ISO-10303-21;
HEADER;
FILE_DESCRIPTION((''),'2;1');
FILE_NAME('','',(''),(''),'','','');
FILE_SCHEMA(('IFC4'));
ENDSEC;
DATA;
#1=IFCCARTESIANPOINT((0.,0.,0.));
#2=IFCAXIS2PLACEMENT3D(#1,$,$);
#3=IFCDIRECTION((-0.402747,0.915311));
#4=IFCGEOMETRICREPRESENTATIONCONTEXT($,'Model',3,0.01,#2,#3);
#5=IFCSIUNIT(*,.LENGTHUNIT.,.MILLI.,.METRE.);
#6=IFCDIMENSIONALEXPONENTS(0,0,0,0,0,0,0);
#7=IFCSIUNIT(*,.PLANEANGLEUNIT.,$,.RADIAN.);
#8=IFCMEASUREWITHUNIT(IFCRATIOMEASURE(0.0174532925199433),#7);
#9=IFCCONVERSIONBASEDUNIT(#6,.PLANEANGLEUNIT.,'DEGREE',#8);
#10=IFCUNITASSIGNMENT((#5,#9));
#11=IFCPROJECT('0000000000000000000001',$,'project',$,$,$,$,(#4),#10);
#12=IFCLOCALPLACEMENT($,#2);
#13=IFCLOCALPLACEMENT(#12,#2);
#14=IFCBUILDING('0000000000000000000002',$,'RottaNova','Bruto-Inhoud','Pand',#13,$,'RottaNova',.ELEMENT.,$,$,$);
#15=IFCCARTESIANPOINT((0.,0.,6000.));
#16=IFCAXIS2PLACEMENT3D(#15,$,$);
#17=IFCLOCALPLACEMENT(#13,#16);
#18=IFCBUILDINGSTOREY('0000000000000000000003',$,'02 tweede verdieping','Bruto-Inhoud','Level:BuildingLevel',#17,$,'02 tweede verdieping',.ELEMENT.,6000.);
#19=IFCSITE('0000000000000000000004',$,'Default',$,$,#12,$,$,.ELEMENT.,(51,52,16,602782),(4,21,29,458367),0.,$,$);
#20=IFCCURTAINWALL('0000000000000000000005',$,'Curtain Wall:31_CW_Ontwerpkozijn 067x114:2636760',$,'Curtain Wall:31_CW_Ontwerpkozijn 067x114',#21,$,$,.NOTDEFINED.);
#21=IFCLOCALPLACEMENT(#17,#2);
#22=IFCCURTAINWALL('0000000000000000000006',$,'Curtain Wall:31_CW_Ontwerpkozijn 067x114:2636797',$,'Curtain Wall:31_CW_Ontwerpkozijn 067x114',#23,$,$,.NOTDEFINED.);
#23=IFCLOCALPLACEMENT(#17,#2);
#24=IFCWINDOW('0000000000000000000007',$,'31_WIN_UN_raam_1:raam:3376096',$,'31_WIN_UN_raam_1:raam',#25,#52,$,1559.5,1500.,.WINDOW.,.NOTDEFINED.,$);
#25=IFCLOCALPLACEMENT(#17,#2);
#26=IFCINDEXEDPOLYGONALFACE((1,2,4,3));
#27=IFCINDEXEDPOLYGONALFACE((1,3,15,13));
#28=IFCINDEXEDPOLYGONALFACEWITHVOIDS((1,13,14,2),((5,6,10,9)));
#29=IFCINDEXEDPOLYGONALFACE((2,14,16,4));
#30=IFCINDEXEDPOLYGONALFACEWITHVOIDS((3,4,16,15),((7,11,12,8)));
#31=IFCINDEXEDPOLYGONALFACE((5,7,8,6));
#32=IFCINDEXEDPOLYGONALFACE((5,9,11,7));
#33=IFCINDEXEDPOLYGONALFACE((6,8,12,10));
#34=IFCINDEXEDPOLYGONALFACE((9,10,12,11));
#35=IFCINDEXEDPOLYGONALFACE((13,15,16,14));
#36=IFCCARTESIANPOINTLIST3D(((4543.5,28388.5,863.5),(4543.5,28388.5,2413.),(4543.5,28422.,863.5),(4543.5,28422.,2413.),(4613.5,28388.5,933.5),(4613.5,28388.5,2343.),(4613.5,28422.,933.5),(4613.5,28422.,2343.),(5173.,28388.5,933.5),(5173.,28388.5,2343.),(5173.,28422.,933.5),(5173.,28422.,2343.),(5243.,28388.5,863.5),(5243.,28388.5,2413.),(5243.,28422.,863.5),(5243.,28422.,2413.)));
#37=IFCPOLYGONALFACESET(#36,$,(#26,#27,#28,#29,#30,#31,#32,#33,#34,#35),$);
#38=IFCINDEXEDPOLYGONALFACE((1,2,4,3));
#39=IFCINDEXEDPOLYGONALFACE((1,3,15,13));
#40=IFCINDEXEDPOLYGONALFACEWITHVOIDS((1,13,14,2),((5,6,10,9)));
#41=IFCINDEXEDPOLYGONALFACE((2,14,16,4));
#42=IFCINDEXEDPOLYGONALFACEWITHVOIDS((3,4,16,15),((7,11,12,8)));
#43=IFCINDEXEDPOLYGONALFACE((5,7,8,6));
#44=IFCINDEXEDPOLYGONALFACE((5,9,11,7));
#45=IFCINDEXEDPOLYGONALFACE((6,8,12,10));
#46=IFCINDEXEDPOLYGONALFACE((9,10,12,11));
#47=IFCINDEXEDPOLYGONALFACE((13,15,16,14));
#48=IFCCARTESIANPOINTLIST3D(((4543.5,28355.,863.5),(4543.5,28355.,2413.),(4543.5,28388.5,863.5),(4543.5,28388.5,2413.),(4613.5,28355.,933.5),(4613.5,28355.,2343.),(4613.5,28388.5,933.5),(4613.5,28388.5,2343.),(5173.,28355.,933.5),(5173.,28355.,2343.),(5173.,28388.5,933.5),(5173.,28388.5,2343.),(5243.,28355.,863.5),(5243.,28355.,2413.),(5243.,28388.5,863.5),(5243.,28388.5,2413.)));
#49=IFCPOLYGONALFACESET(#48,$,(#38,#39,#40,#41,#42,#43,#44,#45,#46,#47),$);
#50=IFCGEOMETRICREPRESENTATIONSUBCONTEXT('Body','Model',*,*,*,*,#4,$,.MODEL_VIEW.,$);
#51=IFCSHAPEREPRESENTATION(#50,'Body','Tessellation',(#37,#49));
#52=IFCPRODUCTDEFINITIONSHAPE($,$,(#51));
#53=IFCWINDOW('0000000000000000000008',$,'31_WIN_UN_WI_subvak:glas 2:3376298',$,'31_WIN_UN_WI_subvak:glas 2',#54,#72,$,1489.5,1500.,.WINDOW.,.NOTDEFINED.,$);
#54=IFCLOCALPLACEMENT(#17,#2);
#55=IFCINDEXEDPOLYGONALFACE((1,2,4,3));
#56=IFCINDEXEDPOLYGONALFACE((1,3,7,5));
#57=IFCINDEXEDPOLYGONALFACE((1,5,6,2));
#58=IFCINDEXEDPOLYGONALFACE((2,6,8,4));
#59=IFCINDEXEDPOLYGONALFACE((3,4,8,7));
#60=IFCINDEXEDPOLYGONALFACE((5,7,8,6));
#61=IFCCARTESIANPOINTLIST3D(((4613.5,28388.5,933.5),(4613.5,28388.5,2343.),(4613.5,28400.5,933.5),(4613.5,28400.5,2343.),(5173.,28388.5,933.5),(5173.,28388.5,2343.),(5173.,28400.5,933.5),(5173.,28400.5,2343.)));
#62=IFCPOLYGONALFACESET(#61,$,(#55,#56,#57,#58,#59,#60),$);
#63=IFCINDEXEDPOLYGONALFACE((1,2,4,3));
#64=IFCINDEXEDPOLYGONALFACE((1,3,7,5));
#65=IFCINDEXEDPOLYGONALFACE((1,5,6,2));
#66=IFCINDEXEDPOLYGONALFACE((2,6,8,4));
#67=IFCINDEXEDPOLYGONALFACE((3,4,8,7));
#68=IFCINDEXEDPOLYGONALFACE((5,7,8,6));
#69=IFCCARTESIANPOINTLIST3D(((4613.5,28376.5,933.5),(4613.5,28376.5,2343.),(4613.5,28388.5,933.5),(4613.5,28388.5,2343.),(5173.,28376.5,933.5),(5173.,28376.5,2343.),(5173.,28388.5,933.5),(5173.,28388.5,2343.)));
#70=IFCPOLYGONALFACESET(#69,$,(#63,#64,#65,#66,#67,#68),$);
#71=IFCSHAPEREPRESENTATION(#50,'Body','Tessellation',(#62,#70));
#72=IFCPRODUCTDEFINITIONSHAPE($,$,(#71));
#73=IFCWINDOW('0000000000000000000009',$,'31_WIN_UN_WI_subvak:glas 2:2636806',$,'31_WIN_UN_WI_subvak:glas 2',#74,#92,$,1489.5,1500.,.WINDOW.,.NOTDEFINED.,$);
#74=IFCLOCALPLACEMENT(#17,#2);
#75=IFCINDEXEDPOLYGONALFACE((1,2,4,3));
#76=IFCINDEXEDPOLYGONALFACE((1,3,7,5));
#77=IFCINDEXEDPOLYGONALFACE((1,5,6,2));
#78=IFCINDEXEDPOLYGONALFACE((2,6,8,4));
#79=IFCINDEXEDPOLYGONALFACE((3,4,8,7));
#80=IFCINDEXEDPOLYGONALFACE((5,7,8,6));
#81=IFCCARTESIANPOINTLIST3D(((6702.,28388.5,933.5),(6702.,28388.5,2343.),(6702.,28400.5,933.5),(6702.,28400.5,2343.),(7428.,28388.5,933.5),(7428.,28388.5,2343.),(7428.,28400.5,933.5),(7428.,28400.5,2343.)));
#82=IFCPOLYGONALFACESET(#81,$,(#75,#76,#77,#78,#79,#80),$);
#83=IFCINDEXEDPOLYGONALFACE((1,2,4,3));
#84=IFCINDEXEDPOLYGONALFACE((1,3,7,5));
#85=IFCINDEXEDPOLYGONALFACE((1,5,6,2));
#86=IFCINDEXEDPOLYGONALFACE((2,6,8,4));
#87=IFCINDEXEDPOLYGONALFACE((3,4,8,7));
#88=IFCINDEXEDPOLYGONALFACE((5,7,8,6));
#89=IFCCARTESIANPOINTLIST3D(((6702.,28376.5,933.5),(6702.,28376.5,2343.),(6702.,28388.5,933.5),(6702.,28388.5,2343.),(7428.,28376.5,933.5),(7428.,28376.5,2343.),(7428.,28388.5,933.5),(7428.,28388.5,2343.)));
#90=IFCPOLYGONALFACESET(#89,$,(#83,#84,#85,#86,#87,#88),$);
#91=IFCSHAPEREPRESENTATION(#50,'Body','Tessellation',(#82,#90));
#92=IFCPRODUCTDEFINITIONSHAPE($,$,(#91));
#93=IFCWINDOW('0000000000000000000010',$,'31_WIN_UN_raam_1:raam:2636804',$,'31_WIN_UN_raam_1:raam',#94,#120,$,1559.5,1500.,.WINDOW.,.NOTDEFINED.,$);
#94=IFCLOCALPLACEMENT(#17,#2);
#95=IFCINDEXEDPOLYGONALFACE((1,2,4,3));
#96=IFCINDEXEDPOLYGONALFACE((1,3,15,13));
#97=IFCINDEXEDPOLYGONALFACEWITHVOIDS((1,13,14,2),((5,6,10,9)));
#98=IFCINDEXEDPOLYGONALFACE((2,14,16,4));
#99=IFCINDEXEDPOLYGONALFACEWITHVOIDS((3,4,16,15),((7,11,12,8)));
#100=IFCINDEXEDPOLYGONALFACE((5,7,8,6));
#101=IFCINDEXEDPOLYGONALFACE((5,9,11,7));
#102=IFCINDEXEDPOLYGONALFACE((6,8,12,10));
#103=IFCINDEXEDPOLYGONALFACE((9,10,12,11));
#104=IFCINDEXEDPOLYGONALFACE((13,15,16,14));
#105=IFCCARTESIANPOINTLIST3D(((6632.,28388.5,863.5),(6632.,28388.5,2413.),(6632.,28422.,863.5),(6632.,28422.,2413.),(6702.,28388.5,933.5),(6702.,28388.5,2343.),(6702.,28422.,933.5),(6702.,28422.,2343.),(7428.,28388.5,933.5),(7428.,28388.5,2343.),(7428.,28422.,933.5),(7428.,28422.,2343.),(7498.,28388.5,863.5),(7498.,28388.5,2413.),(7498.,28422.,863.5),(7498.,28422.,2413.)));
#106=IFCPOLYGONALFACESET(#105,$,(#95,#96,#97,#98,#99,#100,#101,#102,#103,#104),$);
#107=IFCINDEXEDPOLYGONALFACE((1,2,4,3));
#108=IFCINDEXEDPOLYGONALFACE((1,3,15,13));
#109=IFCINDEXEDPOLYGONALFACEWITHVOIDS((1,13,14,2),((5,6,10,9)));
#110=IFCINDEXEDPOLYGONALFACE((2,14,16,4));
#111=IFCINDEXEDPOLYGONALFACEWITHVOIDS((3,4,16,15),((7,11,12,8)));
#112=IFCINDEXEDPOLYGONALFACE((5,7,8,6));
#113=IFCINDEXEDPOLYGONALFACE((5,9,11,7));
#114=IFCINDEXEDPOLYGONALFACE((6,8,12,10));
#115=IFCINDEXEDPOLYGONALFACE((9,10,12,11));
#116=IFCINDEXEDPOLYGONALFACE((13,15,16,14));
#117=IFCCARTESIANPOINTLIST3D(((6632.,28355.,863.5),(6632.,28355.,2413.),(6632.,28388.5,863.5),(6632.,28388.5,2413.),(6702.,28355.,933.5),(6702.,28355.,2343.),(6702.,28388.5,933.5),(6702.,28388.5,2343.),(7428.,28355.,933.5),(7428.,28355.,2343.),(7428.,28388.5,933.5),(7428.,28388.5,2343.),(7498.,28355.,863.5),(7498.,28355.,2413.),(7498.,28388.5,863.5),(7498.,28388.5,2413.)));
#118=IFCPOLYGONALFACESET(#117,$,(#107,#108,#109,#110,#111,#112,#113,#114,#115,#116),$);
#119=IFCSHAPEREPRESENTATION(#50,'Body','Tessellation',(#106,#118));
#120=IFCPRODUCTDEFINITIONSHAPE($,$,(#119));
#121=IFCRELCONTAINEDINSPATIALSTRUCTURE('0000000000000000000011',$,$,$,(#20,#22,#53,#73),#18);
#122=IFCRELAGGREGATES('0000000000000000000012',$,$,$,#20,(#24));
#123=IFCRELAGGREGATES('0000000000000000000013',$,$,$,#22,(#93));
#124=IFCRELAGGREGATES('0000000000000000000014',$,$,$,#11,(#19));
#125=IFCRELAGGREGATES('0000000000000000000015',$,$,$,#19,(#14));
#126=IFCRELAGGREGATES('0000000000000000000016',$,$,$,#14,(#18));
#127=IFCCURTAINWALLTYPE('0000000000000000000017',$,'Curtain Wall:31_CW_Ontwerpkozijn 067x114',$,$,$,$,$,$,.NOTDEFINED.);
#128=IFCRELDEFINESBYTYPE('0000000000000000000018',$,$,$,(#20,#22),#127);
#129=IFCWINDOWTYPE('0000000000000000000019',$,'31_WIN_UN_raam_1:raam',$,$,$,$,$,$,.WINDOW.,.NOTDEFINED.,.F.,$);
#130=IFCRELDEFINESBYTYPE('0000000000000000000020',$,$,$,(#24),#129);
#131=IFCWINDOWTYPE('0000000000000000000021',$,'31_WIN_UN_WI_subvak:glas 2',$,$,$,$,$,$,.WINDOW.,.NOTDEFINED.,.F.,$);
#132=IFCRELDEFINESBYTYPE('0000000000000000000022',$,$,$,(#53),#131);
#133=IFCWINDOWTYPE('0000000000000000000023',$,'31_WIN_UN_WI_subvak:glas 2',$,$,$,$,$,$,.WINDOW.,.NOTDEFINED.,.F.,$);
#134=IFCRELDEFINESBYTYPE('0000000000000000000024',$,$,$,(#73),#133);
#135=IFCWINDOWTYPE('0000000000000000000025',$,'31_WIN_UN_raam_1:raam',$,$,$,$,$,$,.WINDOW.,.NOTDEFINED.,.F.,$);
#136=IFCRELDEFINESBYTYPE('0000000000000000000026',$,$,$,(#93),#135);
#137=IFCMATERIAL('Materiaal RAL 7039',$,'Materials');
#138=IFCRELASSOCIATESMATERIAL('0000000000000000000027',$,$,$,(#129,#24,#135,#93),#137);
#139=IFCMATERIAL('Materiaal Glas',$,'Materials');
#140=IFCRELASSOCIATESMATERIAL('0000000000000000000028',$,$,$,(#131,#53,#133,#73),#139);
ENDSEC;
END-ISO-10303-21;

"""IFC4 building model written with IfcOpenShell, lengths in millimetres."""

from ifc_helpers import new_model, entity, si_unit, converted_unit, direction, frame, frame_2d, origin, origin_2d_with_axis, place, context, subcontext, project, spatial, polyline, rectangle, outline, extrude, source, transform, mapped, material, type_object, type_shapes, element, aggregate, save


model = new_model("IFC4")

# Units and contexts
model_context = context("Model", 3, precision=0.01, world=origin(), true_north=direction((-0.402747, 0.915311)))
body_context = subcontext(model_context, "Body", "Model", "MODEL_VIEW")
ifc_project = project(units=[si_unit("LENGTHUNIT", "METRE", prefix="MILLI"), converted_unit("PLANEANGLEUNIT", "DEGREE", entity("IfcRatioMeasure", 0.0174532925199433), si_unit("PLANEANGLEUNIT", "RADIAN"), dimensions=[0, 0, 0, 0, 0, 0, 0])], contexts=[model_context])

# Site, building, storey
site_placement = place(None, origin())
site = spatial("IfcSite", under=ifc_project, at=site_placement, Name="Default", CompositionType="ELEMENT", RefLatitude=(51, 52, 16, 602782), RefLongitude=(4, 21, 29, 458367), RefElevation=0.0)
building_placement = place(site_placement, origin())
building = spatial("IfcBuilding", under=site, at=building_placement, Name="RottaNova", Description="Bruto-Inhoud", ObjectType="Pand", LongName="RottaNova", CompositionType="ELEMENT")
storey_placement = place(building_placement, frame((0.0, 0.0, 6000.0)))
storey = spatial("IfcBuildingStorey", under=building, at=storey_placement, Name="02 tweede verdieping", Description="Bruto-Inhoud", ObjectType="Level:BuildingLevel", LongName="02 tweede verdieping", CompositionType="ELEMENT", Elevation=6000.0)

# Shared definitions
curtain_wall_type = type_object("IfcCurtainWallType", Name="Curtain Wall:31_CW_Ontwerpkozijn 067x114", PredefinedType="NOTDEFINED")

# Curtain walls
curtain_wall_1_placement = place(storey_placement, frame((0.0, 0.0, -6000.0)))
curtain_wall_1 = element("IfcCurtainWall", 1, at=curtain_wall_1_placement, inside=storey, type_object=curtain_wall_type, Name="Curtain Wall:31_CW_Ontwerpkozijn 067x114:2636760", ObjectType="Curtain Wall:31_CW_Ontwerpkozijn 067x114", PredefinedType="NOTDEFINED")
curtain_wall_2_placement = place(storey_placement, frame((0.0, 0.0, -6000.0)))
curtain_wall_2 = element("IfcCurtainWall", 2, at=curtain_wall_2_placement, inside=storey, type_object=curtain_wall_type, Name="Curtain Wall:31_CW_Ontwerpkozijn 067x114:2636797", ObjectType="Curtain Wall:31_CW_Ontwerpkozijn 067x114", PredefinedType="NOTDEFINED")

# Shared definitions
ifc_material_1 = material(Name="Materiaal Glas", Category="Materials")

# Window
ifc_material_2 = material(Name="Materiaal RAL 7039", Category="Materials")
window_type_1 = type_object("IfcWindowType", Name="31_WIN_UN_raam_1:raam", ParameterTakesPrecedence=False, PartitioningType="NOTDEFINED", PredefinedType="WINDOW", material=ifc_material_2)
shared_shape_1 = source(origin(), body_context, "Body", "SweptSolid", [
    extrude(outline(polyline([(-349.7, -774.7), (349.7, -774.7), (349.7, 774.7), (-349.7, 774.7), (-349.7, -774.7)]), holes=[polyline([(-279.7, 704.7), (279.7, 704.7), (279.7, -704.8), (-279.7, -704.8), (-279.7, 704.7)])]), frame((0.0, 92.0, 774.8), z_axis=(0.0, -1.0, 0.0), x_axis=(-1.0, 0.0, 0.0)), (0.0, 0.0, 1.0), 33.5),
    extrude(outline(polyline([(-349.7, -774.7), (349.7, -774.7), (349.7, 774.7), (-349.7, 774.7), (-349.7, -774.7)]), holes=[polyline([(-279.7, 704.7), (279.7, 704.7), (279.7, -704.8), (-279.7, -704.8), (-279.7, 704.7)])]), frame((0.0, 58.5, 774.8), z_axis=(0.0, -1.0, 0.0), x_axis=(-1.0, 0.0, 0.0)), (0.0, 0.0, 1.0), 33.5),
])
type_shapes(window_type_1, [shared_shape_1])
window_1_placement = place(curtain_wall_1_placement, frame((4893.2, 28330.0, 6863.5)))
window_1 = element("IfcWindow", 3, at=window_1_placement, type_object=window_type_1, material=ifc_material_2, Name="31_WIN_UN_raam_1:raam:3376096", ObjectType="31_WIN_UN_raam_1:raam", OverallHeight=1559.5, OverallWidth=1500.0, PartitioningType="NOTDEFINED", PredefinedType="WINDOW", context=body_context, shape_type="MappedRepresentation", body=[
    mapped(shared_shape_1, transform((0.0, 0.0, 0.0), scale=1.0)),
])
aggregate(curtain_wall_1, [window_1])

# Windows
window_type_2 = type_object("IfcWindowType", Name="31_WIN_UN_WI_subvak:glas 2", ParameterTakesPrecedence=False, PartitioningType="NOTDEFINED", PredefinedType="WINDOW", material=ifc_material_1)
shared_shape_2 = source(origin(), body_context, "Body", "SweptSolid", [
    extrude(rectangle(XDim=559.5, YDim=12.0, at=frame_2d((0.0, 0.0), x_axis=(1.0, 0.0))), frame((0.0, -6.0, 0.0)), (0.0, 0.0, 1.0), 1409.5),
    extrude(rectangle(XDim=559.5, YDim=12.0, at=origin_2d_with_axis()), frame((0.0, 6.0, 0.0)), (0.0, 0.0, 1.0), 1409.5),
])
type_shapes(window_type_2, [shared_shape_2])
window_2_placement = place(storey_placement, frame((4893.2, 28388.5, 933.5), z_axis=(0.0, 0.0, 1.0), x_axis=(-1.0, 0.0, 0.0)))
element("IfcWindow", 4, at=window_2_placement, inside=storey, type_object=window_type_2, material=ifc_material_1, Name="31_WIN_UN_WI_subvak:glas 2:3376298", ObjectType="31_WIN_UN_WI_subvak:glas 2", OverallHeight=1489.5, OverallWidth=1500.0, PartitioningType="NOTDEFINED", PredefinedType="WINDOW", context=body_context, shape_type="MappedRepresentation", body=[
    mapped(shared_shape_2, transform((0.0, 0.0, 0.0), scale=1.0)),
])
window_type_3 = type_object("IfcWindowType", Name="31_WIN_UN_WI_subvak:glas 2", ParameterTakesPrecedence=False, PartitioningType="NOTDEFINED", PredefinedType="WINDOW", material=ifc_material_1)
shared_shape_3 = source(origin(), body_context, "Body", "SweptSolid", [
    extrude(rectangle(XDim=12.0, YDim=726.0, at=frame_2d((0.0, 0.0), x_axis=(1.0, 0.0))), frame((0.0, 6.0, 0.0), z_axis=(0.0, 0.0, 1.0), x_axis=(0.0, -1.0, 0.0)), (0.0, 0.0, 1.0), 1409.5),
    extrude(rectangle(XDim=12.0, YDim=726.0, at=frame_2d((0.0, 0.0), x_axis=(1.0, 0.0))), frame((0.0, -6.0, 0.0), z_axis=(0.0, 0.0, 1.0), x_axis=(0.0, -1.0, 0.0)), (0.0, 0.0, 1.0), 1409.5),
])
type_shapes(window_type_3, [shared_shape_3])
window_3_placement = place(storey_placement, frame((7065.0, 28388.5, 933.5)))
element("IfcWindow", 5, at=window_3_placement, inside=storey, type_object=window_type_3, material=ifc_material_1, Name="31_WIN_UN_WI_subvak:glas 2:2636806", ObjectType="31_WIN_UN_WI_subvak:glas 2", OverallHeight=1489.5, OverallWidth=1500.0, PartitioningType="NOTDEFINED", PredefinedType="WINDOW", context=body_context, shape_type="MappedRepresentation", body=[
    mapped(shared_shape_3, transform((0.0, 0.0, 0.0), scale=1.0)),
])

# Window
window_type_4 = type_object("IfcWindowType", Name="31_WIN_UN_raam_1:raam", ParameterTakesPrecedence=False, PartitioningType="NOTDEFINED", PredefinedType="WINDOW", material=ifc_material_2)
shared_shape_4 = source(origin(), body_context, "Body", "SweptSolid", [
    extrude(outline(polyline([(-433.0, -774.7), (433.0, -774.7), (433.0, 774.7), (-433.0, 774.7), (-433.0, -774.7)]), holes=[polyline([(-363.0, 704.7), (363.0, 704.7), (363.0, -704.8), (-363.0, -704.8), (-363.0, 704.7)])]), frame((0.0, 58.5, 774.8), z_axis=(0.0, 1.0, 0.0), x_axis=(1.0, 0.0, 0.0)), (0.0, 0.0, 1.0), 33.5),
    extrude(outline(polyline([(-433.0, -774.7), (433.0, -774.7), (433.0, 774.7), (-433.0, 774.7), (-433.0, -774.7)]), holes=[polyline([(-363.0, 704.7), (363.0, 704.7), (363.0, -704.8), (-363.0, -704.8), (-363.0, 704.7)])]), frame((0.0, 25.0, 774.8), z_axis=(0.0, 1.0, 0.0), x_axis=(1.0, 0.0, 0.0)), (0.0, 0.0, 1.0), 33.5),
])
type_shapes(window_type_4, [shared_shape_4])
window_4_placement = place(curtain_wall_2_placement, frame((7065.0, 28330.0, 6863.5)))
window_4 = element("IfcWindow", 6, at=window_4_placement, type_object=window_type_4, material=ifc_material_2, Name="31_WIN_UN_raam_1:raam:2636804", ObjectType="31_WIN_UN_raam_1:raam", OverallHeight=1559.5, OverallWidth=1500.0, PartitioningType="NOTDEFINED", PredefinedType="WINDOW", context=body_context, shape_type="MappedRepresentation", body=[
    mapped(shared_shape_4, transform((0.0, 0.0, 0.0), scale=1.0)),
])
aggregate(curtain_wall_2, [window_4])

save(model, "model.ifc")
